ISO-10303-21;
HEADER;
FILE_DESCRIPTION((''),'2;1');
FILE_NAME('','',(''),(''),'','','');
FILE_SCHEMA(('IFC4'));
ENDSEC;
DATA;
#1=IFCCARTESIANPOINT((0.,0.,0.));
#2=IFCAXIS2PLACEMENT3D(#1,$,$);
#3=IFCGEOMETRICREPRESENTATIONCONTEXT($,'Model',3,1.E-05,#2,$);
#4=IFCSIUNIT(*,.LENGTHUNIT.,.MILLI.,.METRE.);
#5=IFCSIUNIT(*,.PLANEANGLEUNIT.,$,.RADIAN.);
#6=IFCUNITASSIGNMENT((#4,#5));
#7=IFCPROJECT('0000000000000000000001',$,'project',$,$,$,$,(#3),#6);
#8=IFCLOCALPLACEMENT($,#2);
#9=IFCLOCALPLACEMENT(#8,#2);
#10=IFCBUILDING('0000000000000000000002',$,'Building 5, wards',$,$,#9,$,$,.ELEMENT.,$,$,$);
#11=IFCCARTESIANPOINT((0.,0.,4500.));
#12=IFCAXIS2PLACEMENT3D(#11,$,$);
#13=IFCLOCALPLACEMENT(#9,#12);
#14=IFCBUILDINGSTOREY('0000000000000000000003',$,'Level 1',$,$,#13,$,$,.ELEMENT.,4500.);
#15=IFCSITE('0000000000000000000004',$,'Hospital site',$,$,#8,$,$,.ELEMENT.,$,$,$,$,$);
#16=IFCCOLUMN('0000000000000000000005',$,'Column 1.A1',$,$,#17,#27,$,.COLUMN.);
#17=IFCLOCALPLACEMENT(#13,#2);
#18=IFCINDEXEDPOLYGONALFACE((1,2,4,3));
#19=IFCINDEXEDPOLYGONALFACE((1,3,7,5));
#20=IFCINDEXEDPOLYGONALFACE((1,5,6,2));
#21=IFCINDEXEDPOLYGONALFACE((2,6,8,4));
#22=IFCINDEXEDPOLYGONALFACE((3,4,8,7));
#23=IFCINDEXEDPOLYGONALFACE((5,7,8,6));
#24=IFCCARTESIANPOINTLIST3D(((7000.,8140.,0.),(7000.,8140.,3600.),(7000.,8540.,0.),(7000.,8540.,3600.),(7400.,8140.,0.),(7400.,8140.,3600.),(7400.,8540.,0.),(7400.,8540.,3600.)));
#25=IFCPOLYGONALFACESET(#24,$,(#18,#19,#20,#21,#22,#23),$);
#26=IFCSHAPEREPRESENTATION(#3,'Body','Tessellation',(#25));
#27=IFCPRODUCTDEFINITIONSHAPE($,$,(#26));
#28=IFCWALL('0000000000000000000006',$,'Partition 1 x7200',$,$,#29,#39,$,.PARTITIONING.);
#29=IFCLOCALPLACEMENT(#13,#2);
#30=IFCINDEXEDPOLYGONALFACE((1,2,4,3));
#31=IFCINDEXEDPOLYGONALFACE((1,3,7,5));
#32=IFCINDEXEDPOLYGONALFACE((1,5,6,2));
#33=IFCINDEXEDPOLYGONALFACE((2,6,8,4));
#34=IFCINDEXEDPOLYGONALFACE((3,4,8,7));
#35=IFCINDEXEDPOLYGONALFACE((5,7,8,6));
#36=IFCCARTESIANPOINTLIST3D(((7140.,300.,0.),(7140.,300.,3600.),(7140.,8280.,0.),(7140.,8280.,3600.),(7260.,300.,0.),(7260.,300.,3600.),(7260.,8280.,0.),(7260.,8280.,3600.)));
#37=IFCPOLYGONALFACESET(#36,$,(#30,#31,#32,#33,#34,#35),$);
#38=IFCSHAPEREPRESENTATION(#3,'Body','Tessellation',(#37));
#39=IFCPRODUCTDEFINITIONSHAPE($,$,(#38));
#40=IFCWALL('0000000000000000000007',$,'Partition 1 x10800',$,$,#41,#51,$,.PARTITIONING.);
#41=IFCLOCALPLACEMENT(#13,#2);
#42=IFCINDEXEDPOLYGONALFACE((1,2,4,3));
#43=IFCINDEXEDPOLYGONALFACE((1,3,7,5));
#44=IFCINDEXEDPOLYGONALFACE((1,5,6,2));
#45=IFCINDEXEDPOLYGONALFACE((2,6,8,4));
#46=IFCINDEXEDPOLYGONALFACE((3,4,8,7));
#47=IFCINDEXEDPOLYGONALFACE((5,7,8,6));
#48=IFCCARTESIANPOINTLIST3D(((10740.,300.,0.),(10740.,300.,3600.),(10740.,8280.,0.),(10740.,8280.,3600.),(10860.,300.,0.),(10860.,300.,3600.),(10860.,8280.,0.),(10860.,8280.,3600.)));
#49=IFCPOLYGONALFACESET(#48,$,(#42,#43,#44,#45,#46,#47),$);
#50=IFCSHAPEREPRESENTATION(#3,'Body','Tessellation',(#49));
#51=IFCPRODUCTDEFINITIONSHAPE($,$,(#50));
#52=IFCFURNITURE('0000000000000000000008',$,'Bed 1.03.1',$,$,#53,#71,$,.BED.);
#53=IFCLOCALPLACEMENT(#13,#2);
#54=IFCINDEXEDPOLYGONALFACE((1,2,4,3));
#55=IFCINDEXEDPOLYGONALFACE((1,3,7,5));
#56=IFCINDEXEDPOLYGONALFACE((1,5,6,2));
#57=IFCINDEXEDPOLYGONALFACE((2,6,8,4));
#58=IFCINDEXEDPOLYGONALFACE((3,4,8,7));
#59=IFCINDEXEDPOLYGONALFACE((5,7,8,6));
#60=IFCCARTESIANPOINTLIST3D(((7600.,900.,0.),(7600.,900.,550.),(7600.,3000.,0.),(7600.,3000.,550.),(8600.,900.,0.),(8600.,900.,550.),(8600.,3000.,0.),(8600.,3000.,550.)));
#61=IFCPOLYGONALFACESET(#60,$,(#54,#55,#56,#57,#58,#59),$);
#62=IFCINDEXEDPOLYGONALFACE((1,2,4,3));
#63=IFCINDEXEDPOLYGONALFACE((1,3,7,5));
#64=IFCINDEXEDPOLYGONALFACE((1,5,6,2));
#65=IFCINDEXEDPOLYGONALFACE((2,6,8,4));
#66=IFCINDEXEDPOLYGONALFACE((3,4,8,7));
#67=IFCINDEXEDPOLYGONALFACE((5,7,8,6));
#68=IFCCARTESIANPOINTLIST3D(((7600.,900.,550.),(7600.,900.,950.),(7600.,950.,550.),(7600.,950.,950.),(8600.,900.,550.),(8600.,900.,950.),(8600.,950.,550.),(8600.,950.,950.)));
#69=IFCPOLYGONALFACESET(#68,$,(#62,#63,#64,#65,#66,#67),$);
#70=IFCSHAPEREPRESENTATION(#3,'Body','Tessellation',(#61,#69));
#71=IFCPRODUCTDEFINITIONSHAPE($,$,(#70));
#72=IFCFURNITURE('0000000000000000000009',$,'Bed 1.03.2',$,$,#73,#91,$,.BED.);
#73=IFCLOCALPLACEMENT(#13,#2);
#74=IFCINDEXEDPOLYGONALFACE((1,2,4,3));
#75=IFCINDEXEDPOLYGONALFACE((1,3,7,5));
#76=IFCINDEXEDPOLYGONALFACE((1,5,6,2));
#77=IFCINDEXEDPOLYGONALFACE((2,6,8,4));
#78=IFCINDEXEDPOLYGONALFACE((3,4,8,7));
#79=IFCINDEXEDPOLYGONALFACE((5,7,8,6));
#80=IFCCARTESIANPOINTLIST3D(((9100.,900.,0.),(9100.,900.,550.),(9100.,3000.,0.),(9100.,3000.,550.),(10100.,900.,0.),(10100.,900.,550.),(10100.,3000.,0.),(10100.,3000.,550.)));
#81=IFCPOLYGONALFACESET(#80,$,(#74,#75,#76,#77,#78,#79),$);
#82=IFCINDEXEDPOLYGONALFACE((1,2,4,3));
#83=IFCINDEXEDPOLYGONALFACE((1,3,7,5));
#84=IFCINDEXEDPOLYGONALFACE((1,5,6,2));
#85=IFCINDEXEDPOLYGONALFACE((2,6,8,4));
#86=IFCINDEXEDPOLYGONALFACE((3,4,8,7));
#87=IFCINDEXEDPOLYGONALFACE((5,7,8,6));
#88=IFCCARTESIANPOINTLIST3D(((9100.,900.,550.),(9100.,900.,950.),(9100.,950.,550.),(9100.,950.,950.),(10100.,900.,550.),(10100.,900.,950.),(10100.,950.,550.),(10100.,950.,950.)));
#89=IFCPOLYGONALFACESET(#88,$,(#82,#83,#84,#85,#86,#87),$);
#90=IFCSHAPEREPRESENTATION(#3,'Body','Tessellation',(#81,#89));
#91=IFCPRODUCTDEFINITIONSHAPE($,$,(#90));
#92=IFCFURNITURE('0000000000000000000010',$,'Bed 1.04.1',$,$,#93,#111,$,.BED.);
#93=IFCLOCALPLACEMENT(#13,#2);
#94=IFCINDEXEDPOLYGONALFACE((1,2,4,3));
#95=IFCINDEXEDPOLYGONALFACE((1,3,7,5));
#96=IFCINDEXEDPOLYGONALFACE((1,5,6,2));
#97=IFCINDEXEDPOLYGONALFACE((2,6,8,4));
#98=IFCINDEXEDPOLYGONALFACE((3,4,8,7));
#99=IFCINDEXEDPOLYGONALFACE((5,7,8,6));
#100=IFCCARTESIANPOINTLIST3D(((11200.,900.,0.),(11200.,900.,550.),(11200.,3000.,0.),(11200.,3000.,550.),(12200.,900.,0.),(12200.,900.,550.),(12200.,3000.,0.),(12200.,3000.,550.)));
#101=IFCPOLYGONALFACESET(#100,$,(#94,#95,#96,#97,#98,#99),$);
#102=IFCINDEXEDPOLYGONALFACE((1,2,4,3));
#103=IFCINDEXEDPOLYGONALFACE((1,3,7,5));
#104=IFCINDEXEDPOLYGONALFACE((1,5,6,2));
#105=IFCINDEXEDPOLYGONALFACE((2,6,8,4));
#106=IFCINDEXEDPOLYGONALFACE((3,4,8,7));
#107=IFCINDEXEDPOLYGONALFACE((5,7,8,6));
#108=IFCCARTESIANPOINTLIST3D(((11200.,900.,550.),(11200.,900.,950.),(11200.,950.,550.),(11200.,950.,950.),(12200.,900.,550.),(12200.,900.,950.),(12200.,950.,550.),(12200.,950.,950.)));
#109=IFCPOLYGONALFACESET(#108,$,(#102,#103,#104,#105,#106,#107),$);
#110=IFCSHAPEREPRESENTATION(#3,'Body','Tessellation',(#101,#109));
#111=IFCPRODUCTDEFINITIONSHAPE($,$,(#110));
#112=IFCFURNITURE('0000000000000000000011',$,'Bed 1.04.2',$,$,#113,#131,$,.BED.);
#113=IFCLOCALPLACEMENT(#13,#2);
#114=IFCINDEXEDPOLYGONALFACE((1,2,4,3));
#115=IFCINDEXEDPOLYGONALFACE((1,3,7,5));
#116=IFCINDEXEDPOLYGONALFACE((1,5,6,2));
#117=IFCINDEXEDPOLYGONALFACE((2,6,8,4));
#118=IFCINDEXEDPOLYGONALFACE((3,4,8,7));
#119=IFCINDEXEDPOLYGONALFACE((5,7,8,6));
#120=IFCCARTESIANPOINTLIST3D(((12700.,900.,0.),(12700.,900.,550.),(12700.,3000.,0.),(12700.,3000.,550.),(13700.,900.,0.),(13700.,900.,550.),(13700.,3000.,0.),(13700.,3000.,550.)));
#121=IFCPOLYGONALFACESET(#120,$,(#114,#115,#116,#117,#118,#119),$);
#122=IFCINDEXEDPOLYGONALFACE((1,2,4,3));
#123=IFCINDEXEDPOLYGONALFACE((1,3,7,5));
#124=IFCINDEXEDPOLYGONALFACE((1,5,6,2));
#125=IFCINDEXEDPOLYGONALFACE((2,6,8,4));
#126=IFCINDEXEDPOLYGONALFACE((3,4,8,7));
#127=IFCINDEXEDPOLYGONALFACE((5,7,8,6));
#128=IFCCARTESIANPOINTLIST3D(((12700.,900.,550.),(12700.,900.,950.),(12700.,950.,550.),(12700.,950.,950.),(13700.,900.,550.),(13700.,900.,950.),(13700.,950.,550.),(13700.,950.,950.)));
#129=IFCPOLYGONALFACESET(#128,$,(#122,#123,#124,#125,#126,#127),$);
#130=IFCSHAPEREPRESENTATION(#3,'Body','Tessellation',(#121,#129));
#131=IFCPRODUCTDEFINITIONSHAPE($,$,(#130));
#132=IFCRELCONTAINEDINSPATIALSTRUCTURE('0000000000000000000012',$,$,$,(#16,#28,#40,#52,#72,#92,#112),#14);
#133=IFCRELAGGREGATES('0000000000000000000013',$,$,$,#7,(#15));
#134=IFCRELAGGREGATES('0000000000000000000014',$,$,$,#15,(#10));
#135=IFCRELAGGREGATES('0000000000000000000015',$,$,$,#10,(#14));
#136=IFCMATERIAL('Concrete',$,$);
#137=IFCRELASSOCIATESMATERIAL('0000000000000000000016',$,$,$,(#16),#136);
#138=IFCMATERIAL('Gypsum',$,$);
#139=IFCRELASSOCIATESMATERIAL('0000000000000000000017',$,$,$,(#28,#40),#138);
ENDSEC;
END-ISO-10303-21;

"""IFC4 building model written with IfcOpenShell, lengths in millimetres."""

from ifc_helpers import new_model, si_unit, frame, frame_2d, origin, origin_2d, place, context, project, spatial, rectangle, extrude, material, element, save


model = new_model("IFC4")

# Units and contexts
model_context = context("Model", 3, precision=1e-05, world=origin())
ifc_project = project(units=[si_unit("LENGTHUNIT", "METRE", prefix="MILLI"), si_unit("PLANEANGLEUNIT", "RADIAN")], contexts=[model_context])

# Site, building, storey
site_placement = place(None, origin())
site = spatial("IfcSite", under=ifc_project, at=site_placement, Name="Hospital site", CompositionType="ELEMENT")
building_placement = place(site_placement, origin())
building = spatial("IfcBuilding", under=site, at=building_placement, Name="Building 5, wards", CompositionType="ELEMENT")
storey_placement = place(building_placement, frame((0.0, 0.0, 4500.0)))
storey = spatial("IfcBuildingStorey", under=building, at=storey_placement, Name="Level 1", CompositionType="ELEMENT", Elevation=4500.0)

# Column
ifc_material_1 = material(Name="Concrete")
column_placement = place(storey_placement, frame((7200.0, 8340.0, 0.0)))
element("IfcColumn", 1, at=column_placement, inside=storey, material=ifc_material_1, Name="Column 1.A1", PredefinedType="COLUMN", context=model_context, shape_type="SweptSolid", body=[
    extrude(rectangle(XDim=400.0, YDim=400.0, at=origin_2d()), origin(), (0.0, 0.0, 1.0), 3600.0),
])

# Walls
ifc_material_2 = material(Name="Gypsum")
for number, where, x_axis, name in (
    (2, (7260.0, 300.0, 0.0), (0.0, 1.0, 0.0), "Partition 1 x7200"),
    (3, (10860.0, 300.0, 0.0), (0.0, 1.0, 0.0), "Partition 1 x10800"),
):
    element("IfcWall", number, at=place(storey_placement, frame(where, x_axis=x_axis)), inside=storey, material=ifc_material_2, Name=name, PredefinedType="PARTITIONING", context=model_context, shape_type="SweptSolid", body=[
        extrude(rectangle(XDim=7980.0, YDim=120.0, at=frame_2d((3990.0, 60.0))), origin(), (0.0, 0.0, 1.0), 3600.0),
    ])

# Furniture
for number, where, name in (
    (4, (7600.0, 900.0, 0.0), "Bed 1.03.1"),
    (5, (9100.0, 900.0, 0.0), "Bed 1.03.2"),
    (6, (11200.0, 900.0, 0.0), "Bed 1.04.1"),
    (7, (12700.0, 900.0, 0.0), "Bed 1.04.2"),
):
    element("IfcFurniture", number, at=place(storey_placement, frame(where)), inside=storey, Name=name, PredefinedType="BED", context=model_context, shape_type="SweptSolid", body=[
        extrude(rectangle(XDim=1000.0, YDim=2100.0, at=frame_2d((500.0, 1050.0))), origin(), (0.0, 0.0, 1.0), 550.0),
        extrude(rectangle(XDim=1000.0, YDim=50.0, at=frame_2d((500.0, 25.0))), frame((0.0, 0.0, 550.0)), (0.0, 0.0, 1.0), 400.0),
    ])

save(model, "model.ifc")
